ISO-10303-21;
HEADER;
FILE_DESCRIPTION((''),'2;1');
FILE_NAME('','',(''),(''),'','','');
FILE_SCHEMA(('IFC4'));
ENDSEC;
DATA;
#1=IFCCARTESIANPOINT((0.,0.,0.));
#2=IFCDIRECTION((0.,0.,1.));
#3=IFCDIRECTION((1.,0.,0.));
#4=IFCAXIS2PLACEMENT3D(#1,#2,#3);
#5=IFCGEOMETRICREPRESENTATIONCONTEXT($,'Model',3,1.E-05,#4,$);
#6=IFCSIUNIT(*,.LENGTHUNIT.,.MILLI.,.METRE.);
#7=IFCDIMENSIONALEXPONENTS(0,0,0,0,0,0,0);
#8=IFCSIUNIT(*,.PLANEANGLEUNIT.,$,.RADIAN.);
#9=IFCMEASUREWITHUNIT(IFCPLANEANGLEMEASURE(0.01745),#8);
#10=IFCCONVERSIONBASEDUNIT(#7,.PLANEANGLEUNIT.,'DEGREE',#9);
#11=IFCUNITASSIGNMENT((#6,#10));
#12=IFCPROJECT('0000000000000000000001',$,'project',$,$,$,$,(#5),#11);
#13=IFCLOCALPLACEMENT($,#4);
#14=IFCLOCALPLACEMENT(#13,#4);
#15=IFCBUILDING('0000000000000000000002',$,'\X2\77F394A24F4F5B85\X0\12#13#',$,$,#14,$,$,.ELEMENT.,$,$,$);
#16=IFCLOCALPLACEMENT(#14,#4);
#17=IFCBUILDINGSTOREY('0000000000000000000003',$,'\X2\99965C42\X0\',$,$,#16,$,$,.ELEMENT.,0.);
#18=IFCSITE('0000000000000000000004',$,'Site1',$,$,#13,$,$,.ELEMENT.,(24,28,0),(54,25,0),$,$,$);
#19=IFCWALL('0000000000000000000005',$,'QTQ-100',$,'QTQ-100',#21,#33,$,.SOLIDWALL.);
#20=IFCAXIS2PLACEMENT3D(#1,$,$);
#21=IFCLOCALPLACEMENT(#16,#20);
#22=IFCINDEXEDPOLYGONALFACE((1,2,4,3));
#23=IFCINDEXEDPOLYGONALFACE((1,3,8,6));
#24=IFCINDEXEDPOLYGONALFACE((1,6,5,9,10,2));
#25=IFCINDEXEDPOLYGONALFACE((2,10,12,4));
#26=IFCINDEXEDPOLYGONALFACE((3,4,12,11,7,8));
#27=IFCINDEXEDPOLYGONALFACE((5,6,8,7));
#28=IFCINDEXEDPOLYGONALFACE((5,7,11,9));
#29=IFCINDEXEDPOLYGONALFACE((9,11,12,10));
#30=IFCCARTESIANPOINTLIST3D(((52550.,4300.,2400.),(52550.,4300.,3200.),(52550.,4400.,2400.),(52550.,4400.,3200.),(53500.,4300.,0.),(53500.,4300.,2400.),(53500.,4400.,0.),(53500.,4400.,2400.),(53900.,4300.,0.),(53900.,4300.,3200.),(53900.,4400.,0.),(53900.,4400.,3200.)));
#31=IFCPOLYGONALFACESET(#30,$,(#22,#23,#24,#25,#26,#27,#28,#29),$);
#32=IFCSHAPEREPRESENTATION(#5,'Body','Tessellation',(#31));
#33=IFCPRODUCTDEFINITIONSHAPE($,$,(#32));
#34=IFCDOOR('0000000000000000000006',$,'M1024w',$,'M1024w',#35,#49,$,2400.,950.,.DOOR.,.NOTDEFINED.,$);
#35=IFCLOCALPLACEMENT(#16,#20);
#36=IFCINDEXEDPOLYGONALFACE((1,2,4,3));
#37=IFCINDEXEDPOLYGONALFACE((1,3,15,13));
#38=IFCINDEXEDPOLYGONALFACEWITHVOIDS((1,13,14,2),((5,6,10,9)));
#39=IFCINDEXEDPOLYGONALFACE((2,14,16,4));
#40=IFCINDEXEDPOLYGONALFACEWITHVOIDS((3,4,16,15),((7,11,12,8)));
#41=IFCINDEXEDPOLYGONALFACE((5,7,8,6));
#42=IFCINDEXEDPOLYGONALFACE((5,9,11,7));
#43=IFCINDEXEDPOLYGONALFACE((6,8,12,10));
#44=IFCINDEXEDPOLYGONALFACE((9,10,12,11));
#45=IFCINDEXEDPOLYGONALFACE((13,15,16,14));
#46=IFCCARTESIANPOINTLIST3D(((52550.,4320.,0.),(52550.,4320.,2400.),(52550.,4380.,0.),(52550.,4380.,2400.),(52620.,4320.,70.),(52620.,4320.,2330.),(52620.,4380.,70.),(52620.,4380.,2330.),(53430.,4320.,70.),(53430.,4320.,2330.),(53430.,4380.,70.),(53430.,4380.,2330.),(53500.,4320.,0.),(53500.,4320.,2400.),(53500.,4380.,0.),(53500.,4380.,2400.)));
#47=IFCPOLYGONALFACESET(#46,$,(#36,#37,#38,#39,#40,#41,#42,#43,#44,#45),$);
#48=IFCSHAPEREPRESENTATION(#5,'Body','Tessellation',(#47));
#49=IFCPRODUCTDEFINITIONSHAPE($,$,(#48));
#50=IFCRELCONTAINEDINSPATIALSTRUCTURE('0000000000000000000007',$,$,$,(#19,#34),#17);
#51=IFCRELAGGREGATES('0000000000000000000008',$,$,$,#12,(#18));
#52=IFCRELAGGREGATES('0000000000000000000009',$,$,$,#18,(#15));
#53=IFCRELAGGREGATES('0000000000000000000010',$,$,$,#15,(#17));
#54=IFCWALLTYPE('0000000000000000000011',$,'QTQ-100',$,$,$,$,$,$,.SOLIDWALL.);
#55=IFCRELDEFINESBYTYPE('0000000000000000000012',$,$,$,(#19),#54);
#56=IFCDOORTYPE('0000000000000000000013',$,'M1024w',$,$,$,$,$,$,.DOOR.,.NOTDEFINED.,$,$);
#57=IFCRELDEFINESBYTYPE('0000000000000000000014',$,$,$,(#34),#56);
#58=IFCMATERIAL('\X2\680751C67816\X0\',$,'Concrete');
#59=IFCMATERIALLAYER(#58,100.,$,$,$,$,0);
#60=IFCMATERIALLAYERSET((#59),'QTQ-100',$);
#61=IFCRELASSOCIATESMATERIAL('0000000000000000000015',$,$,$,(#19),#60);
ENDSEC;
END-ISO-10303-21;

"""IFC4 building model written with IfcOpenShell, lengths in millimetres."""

from ifc_helpers import new_model, entity, si_unit, converted_unit, frame, origin_with_axes, place, context, project, spatial, polyline, outline, extrude, material, layer, layer_set, type_object, element, fill, save


model = new_model("IFC4")

# Units and contexts
model_context = context("Model", 3, precision=1e-05, world=origin_with_axes())
ifc_project = project(units=[si_unit("LENGTHUNIT", "METRE", prefix="MILLI"), converted_unit("PLANEANGLEUNIT", "DEGREE", entity("IfcPlaneAngleMeasure", 0.01745), si_unit("PLANEANGLEUNIT", "RADIAN"), dimensions=[0, 0, 0, 0, 0, 0, 0])], contexts=[model_context])

# Site, building, storey
site_placement = place(None, origin_with_axes())
site = spatial("IfcSite", under=ifc_project, at=site_placement, Name="Site1", CompositionType="ELEMENT", RefLatitude=(24, 28, 0), RefLongitude=(54, 25, 0))
building_placement = place(site_placement, origin_with_axes())
building = spatial("IfcBuilding", under=site, at=building_placement, Name="石钢住宅12#13#", CompositionType="ELEMENT")
storey_placement = place(building_placement, origin_with_axes())
storey = spatial("IfcBuildingStorey", under=building, at=storey_placement, Name="首层", CompositionType="ELEMENT", Elevation=0.0)

# Shared definitions
ifc_material = material(Name="标准砖", Category="Concrete")
ifc_layer = layer(ifc_material, 100.0, Priority=0)
ifc_layer_set = layer_set([ifc_layer], Name="QTQ-100")
wall_type = type_object("IfcWallType", Name="QTQ-100", PredefinedType="SOLIDWALL")

# Wall, opening, door
wall_1_placement = place(storey_placement, origin_with_axes())
wall_1 = element("IfcWall", 1, at=wall_1_placement, inside=storey, type_object=wall_type, material=ifc_layer_set, Name="QTQ-100", ObjectType="QTQ-100", PredefinedType="SOLIDWALL", context=model_context, shape_type="SweptSolid", body=[
    extrude(outline(polyline([(0.0, 0.0), (3200.0, 0.0), (3200.0, 1350.0), (0.0, 1350.0), (0.0, 0.0)])), frame((53900.0, 4300.0, 3200.0), z_axis=(0.0, 1.0, 0.0), x_axis=(0.0, 0.0, -1.0)), (0.0, 0.0, 1.0), 100.0),
])
opening_1_placement = place(storey_placement, origin_with_axes())
opening_1 = element("IfcOpeningElement", 2, at=opening_1_placement, cuts=wall_1, PredefinedType="OPENING", context=model_context, shape_type="SweptSolid", body=[
    extrude(outline(polyline([(0.0, 0.0), (950.0, 0.0), (950.0, 2400.0), (0.0, 2400.0), (0.0, 0.0)])), frame((53500.0, 3300.0, 0.0), z_axis=(0.0, 1.0, 0.0), x_axis=(-1.0, 0.0, 0.0)), (0.0, 0.0, 1.0), 2100.0),
])
door_type_1 = type_object("IfcDoorType", Name="M1024w", OperationType="NOTDEFINED", PredefinedType="DOOR")
door_1_placement = place(storey_placement, origin_with_axes())
door_1 = element("IfcDoor", 3, at=door_1_placement, inside=storey, type_object=door_type_1, Name="M1024w", ObjectType="M1024w", OperationType="NOTDEFINED", OverallHeight=2400.0, OverallWidth=950.0, PredefinedType="DOOR", context=model_context, shape_type="SweptSolid", body=[
    extrude(outline(polyline([(-475.0, -1200.0), (475.0, -1200.0), (475.0, 1200.0), (-475.0, 1200.0), (-475.0, -1200.0)]), holes=[polyline([(-405.0, -1130.0), (-405.0, 1130.0), (405.0, 1130.0), (405.0, -1130.0), (-405.0, -1130.0)])]), frame((53025.0, 4320.0, 1200.0), z_axis=(0.0, 1.0, 0.0), x_axis=(-1.0, 0.0, 0.0)), (0.0, 0.0, 1.0), 60.0),
])
fill(opening_1, door_1)

save(model, "model.ifc")
